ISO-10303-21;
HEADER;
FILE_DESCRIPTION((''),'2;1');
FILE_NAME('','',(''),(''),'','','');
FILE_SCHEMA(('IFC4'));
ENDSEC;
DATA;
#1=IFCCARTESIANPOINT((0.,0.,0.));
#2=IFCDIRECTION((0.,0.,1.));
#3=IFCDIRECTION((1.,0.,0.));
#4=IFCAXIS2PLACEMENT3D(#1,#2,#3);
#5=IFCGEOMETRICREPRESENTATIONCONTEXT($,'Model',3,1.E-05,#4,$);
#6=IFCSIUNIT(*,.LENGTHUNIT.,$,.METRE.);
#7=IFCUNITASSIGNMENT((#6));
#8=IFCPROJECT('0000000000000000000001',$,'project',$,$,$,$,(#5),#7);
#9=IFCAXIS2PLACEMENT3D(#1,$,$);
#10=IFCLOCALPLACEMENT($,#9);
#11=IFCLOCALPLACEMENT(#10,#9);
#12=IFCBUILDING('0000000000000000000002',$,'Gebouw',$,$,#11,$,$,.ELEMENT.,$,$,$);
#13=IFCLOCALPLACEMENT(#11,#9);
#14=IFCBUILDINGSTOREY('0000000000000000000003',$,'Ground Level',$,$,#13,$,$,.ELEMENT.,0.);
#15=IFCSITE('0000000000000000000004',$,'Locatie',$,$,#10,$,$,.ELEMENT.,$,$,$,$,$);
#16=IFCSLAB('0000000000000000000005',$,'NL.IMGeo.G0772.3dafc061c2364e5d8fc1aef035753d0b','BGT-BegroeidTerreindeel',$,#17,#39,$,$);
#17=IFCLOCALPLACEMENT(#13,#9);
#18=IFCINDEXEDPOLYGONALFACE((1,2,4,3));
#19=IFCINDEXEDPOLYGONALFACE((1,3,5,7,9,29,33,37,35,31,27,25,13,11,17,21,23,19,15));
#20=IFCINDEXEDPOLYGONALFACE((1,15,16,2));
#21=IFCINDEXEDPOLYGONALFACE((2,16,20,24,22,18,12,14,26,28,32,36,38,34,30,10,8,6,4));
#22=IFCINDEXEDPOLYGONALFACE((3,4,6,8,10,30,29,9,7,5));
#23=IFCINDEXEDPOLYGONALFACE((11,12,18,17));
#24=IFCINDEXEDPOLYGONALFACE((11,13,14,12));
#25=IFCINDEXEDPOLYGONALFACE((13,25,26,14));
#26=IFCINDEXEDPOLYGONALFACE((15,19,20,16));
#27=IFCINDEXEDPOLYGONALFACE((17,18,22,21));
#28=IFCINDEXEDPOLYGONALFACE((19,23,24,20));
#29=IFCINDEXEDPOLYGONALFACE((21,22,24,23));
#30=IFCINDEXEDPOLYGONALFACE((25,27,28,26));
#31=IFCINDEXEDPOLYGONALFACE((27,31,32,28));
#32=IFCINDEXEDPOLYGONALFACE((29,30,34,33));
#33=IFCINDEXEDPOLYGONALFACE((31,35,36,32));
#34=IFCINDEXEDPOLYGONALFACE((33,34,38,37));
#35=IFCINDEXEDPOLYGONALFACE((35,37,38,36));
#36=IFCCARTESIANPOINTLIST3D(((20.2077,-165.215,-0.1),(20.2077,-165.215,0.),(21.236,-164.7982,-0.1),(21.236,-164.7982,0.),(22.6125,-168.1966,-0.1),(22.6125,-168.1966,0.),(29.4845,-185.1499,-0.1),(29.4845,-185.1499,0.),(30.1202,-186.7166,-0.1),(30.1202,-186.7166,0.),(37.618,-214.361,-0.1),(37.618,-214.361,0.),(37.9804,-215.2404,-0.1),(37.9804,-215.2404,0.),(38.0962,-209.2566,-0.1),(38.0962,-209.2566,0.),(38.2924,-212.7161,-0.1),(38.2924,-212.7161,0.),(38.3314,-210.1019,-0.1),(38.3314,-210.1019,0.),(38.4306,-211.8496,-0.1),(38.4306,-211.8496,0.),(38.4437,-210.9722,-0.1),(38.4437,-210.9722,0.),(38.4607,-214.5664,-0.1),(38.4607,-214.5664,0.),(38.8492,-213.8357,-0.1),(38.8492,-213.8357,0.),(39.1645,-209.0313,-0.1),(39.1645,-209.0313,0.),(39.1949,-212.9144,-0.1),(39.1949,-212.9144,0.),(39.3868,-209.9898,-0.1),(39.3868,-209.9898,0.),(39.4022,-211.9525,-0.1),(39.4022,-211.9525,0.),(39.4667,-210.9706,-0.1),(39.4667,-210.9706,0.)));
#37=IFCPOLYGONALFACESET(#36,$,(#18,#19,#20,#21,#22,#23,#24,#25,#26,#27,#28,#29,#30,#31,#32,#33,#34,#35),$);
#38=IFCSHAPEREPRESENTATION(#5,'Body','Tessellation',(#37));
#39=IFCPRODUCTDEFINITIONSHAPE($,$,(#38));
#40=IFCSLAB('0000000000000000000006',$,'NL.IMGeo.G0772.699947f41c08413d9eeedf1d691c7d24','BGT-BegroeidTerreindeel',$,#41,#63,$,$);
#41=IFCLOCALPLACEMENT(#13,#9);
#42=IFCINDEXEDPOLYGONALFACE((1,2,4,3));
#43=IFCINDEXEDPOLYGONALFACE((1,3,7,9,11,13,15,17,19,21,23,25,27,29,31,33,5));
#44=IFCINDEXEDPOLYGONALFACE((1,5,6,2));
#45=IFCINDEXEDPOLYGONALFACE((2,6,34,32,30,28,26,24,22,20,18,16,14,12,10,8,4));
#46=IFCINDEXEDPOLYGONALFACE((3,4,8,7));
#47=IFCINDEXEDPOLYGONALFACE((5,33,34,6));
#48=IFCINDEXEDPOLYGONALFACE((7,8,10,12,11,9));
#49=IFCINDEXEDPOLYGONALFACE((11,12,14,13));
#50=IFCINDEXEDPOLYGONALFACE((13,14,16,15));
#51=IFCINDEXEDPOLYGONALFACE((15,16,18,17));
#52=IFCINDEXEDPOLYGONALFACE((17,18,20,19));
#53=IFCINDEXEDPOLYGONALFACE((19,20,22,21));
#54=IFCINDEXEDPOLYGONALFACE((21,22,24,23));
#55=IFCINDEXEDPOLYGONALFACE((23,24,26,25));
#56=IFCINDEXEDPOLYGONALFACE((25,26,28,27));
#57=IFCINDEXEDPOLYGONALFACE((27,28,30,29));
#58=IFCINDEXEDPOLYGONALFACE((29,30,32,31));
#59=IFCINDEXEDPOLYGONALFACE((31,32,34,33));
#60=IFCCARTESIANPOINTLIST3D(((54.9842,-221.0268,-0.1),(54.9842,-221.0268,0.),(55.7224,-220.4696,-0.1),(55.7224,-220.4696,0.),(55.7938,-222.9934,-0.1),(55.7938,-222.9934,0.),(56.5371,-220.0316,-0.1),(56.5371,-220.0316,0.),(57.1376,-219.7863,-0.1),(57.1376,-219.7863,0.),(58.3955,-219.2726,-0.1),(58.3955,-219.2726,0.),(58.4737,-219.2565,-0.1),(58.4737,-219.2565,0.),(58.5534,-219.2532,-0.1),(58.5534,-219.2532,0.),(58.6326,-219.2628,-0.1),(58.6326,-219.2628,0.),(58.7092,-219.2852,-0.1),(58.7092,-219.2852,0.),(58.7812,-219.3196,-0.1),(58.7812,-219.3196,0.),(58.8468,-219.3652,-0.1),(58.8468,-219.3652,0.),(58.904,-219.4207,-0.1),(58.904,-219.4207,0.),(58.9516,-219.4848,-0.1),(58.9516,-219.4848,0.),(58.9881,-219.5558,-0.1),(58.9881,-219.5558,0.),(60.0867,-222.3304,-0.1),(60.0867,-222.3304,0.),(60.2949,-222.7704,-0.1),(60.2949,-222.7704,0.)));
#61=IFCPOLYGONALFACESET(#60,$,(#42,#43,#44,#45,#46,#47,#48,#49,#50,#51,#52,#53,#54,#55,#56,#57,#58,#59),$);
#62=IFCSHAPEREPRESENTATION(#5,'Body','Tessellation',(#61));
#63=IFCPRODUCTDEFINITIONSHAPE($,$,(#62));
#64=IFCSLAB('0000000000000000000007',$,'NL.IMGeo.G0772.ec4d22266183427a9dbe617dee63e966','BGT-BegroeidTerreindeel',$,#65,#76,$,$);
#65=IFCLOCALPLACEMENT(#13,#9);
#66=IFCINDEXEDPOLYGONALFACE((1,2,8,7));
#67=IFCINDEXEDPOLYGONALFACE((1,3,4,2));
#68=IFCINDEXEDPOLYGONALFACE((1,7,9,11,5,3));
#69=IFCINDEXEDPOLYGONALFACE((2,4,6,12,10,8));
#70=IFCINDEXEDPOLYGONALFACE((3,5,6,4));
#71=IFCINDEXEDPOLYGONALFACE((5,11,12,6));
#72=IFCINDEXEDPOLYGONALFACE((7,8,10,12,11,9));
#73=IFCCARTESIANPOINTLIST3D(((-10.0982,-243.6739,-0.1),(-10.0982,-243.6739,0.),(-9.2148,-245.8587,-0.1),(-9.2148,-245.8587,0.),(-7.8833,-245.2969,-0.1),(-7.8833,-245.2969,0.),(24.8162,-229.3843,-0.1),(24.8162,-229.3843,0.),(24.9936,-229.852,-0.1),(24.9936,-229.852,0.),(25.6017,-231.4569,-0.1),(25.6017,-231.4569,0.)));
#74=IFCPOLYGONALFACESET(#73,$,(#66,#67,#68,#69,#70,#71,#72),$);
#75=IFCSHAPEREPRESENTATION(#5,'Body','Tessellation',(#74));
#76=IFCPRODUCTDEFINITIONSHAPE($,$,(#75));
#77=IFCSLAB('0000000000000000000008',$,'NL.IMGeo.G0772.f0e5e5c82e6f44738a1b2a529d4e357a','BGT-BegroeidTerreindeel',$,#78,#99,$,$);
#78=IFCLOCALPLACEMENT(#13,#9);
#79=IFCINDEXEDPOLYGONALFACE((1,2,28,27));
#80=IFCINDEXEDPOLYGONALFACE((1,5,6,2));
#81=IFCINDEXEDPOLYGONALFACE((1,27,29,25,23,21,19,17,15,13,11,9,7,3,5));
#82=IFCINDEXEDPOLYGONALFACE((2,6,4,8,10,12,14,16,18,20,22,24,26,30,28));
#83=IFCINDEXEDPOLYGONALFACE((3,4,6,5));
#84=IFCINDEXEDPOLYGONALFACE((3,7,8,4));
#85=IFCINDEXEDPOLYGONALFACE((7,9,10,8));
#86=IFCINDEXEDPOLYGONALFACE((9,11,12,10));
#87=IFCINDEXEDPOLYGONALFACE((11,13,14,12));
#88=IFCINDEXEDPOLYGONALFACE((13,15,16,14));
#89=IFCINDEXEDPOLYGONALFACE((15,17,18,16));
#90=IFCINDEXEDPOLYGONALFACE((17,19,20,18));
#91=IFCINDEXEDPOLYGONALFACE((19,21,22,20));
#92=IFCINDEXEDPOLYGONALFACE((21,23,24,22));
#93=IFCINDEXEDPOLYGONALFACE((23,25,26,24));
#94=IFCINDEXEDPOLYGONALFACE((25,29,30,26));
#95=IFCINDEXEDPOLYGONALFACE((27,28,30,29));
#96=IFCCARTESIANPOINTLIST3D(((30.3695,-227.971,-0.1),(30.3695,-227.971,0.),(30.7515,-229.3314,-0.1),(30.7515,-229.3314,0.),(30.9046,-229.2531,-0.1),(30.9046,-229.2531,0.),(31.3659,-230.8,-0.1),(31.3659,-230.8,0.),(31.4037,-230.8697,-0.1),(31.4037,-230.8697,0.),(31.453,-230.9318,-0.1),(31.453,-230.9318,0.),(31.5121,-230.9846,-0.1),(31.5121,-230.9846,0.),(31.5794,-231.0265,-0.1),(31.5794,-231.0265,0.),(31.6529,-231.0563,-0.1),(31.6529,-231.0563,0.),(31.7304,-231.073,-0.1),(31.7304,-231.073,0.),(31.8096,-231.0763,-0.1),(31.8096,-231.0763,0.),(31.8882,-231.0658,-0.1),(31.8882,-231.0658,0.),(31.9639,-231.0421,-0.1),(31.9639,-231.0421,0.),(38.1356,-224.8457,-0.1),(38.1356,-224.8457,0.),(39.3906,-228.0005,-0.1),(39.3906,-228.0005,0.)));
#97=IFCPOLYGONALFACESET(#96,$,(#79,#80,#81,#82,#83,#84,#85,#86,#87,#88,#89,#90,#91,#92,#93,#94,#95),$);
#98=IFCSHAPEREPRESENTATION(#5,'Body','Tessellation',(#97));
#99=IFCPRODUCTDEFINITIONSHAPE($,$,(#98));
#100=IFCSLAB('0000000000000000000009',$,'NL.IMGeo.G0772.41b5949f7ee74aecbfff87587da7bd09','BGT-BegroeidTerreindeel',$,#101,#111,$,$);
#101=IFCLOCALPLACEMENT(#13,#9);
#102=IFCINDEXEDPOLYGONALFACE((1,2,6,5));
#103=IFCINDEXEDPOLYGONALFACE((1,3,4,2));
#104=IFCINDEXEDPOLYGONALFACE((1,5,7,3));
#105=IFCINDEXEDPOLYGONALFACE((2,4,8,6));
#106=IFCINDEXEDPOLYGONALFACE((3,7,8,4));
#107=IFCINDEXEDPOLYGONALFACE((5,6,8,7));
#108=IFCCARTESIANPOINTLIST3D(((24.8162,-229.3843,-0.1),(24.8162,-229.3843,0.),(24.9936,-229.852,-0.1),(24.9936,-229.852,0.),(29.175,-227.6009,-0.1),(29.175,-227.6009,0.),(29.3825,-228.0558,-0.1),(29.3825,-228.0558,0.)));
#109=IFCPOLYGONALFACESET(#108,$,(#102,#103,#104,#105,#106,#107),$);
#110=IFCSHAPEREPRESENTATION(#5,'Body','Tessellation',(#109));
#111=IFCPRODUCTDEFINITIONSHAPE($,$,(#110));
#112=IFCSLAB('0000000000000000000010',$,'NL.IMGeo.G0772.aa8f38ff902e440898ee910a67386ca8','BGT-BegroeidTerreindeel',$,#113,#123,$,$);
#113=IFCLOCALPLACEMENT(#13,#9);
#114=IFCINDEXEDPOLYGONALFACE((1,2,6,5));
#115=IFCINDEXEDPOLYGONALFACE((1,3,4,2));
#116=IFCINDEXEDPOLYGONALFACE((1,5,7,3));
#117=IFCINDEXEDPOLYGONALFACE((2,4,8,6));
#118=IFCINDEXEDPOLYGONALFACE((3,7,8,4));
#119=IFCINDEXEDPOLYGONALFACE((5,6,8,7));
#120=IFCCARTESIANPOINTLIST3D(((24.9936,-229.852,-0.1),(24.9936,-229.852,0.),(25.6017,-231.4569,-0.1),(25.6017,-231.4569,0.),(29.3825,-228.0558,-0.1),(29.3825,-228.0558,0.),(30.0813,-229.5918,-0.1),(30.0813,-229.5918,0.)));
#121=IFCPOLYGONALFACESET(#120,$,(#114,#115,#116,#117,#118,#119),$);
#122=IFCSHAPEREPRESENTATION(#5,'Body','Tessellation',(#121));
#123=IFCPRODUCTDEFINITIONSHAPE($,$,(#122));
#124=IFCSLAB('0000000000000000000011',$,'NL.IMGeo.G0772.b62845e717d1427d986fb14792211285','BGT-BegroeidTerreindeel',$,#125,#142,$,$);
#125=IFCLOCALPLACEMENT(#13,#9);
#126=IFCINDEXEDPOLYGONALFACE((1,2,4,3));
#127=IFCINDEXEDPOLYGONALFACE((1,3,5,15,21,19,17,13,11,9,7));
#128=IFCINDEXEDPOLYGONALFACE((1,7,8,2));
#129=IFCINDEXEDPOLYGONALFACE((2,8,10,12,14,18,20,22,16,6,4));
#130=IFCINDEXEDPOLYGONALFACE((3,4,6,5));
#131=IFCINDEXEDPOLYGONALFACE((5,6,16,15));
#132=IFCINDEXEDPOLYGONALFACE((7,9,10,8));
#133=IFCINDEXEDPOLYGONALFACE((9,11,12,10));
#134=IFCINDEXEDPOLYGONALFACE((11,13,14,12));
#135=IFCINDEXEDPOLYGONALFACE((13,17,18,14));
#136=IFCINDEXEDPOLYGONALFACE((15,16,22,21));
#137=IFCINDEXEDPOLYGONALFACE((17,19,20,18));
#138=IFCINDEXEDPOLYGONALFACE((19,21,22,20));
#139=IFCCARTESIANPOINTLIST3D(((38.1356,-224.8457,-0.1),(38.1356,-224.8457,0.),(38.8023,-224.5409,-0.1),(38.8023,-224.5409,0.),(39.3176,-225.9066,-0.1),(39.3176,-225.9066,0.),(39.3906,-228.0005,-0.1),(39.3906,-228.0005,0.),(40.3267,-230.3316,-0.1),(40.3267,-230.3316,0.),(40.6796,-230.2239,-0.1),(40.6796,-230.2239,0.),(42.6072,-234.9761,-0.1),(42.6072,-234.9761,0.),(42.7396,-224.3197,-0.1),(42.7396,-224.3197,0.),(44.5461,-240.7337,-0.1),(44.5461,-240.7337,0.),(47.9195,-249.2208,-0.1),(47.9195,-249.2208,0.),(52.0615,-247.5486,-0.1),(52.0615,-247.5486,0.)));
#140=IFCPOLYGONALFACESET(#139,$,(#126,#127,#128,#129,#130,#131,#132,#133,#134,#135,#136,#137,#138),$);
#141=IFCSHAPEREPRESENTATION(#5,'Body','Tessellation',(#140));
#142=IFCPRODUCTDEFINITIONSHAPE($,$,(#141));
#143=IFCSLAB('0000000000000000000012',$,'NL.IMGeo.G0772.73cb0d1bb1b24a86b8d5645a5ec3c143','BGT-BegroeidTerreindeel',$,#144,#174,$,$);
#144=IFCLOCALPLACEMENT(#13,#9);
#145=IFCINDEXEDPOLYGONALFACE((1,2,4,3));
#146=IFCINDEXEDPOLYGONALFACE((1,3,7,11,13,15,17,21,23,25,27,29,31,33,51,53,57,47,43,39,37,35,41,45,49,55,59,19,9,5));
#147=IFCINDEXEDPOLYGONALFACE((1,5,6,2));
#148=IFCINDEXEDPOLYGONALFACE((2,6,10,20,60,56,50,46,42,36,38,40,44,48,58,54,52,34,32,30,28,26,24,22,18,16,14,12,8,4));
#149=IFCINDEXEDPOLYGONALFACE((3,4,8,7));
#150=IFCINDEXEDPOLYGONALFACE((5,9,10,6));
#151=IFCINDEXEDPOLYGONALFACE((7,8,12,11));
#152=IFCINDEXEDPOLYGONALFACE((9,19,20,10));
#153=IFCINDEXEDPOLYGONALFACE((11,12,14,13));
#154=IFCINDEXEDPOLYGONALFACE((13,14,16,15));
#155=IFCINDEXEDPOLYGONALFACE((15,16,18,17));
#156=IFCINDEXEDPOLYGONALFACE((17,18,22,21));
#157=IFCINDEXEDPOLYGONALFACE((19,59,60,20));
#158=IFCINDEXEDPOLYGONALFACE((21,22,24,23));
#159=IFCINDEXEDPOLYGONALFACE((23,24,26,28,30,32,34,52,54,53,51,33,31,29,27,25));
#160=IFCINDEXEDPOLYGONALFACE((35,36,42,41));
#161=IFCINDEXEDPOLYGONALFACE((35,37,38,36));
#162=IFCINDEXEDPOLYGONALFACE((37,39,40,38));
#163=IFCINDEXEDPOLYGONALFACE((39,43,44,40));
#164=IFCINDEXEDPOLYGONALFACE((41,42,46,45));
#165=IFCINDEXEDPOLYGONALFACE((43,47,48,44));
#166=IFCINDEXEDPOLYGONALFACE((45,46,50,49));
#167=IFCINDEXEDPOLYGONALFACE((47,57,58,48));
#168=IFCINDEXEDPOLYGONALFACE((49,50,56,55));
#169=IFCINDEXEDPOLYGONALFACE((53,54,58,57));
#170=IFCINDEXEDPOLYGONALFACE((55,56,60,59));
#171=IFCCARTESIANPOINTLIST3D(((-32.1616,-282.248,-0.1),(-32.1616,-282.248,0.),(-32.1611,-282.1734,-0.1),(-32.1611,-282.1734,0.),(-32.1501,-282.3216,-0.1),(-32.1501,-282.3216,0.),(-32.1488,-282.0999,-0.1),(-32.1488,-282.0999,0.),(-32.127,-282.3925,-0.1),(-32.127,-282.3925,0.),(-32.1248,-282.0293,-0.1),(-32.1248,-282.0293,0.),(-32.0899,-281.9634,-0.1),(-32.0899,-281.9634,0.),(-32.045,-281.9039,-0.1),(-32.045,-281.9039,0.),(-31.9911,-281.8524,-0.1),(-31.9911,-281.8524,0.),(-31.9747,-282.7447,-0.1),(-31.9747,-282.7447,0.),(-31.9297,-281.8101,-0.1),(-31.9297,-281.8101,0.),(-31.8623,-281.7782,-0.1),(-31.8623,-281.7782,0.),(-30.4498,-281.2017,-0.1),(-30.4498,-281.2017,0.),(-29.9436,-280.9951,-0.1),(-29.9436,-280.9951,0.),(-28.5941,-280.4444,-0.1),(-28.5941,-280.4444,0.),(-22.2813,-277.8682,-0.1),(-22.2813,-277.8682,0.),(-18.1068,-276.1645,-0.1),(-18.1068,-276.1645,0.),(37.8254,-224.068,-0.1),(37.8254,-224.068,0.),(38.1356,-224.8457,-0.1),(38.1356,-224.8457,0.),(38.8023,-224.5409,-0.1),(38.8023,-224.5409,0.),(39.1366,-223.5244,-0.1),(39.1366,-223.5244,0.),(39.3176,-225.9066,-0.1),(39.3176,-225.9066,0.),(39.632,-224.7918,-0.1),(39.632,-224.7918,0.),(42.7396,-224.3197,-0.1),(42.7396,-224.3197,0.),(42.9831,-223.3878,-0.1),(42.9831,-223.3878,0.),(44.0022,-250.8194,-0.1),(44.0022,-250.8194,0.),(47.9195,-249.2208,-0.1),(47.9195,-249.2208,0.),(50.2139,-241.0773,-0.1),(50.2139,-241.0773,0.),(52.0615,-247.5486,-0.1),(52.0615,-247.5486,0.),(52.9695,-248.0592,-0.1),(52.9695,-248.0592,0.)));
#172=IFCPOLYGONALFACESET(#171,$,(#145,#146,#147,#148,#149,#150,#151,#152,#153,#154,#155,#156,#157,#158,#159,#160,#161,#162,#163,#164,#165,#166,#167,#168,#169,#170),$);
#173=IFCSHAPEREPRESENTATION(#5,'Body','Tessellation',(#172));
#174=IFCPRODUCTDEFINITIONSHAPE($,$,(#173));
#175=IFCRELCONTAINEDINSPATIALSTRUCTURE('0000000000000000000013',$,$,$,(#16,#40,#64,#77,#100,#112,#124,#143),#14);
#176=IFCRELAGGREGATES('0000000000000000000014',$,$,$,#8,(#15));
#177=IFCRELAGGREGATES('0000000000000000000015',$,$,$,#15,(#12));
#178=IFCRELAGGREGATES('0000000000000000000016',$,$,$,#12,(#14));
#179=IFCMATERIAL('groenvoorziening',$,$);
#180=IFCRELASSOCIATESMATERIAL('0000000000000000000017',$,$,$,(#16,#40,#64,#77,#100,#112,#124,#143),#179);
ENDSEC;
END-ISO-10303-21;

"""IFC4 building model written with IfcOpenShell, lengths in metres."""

from ifc_helpers import new_model, si_unit, frame, origin, origin_with_axes, place, context, project, spatial, polyline, outline, extrude, material, element, save


model = new_model("IFC4")

# Units and contexts
model_context = context("Model", 3, precision=1e-05, world=origin_with_axes())
ifc_project = project(units=[si_unit("LENGTHUNIT", "METRE")], contexts=[model_context])

# Site, building, storey
site_placement = place(None, origin())
site = spatial("IfcSite", under=ifc_project, at=site_placement, Name="Locatie", CompositionType="ELEMENT")
building_placement = place(site_placement, origin())
building = spatial("IfcBuilding", under=site, at=building_placement, Name="Gebouw", CompositionType="ELEMENT")
storey_placement = place(building_placement, origin())
storey = spatial("IfcBuildingStorey", under=building, at=storey_placement, Name="Ground Level", CompositionType="ELEMENT", Elevation=0.0)

# Slabs
ifc_material_1 = material(Name="groenvoorziening")
slab_1_placement = place(storey_placement, origin())
element("IfcSlab", 1, at=slab_1_placement, inside=storey, material=ifc_material_1, Name="NL.IMGeo.G0772.3dafc061c2364e5d8fc1aef035753d0b", Description="BGT-BegroeidTerreindeel", context=model_context, shape_type="SweptSolid", body=[
    extrude(outline(polyline([(29.4845, -185.1499), (30.1202, -186.7166), (39.1645, -209.0313), (39.3868, -209.9898), (39.4667, -210.9706), (39.4022, -211.9525), (39.1949, -212.9144), (38.8492, -213.8357), (38.4607, -214.5664), (37.9804, -215.2404), (37.618, -214.361), (38.2924, -212.7161), (38.4306, -211.8496), (38.4437, -210.9722), (38.3314, -210.1019), (38.0962, -209.2566), (20.2077, -165.215), (21.236, -164.7982), (22.6125, -168.1966), (29.4845, -185.1499)])), frame((0.0, 0.0, -0.1), z_axis=(0.0, 0.0, 1.0), x_axis=(1.0, 0.0, 0.0)), (0.0, 0.0, 1.0), 0.1),
])
slab_2_placement = place(storey_placement, origin())
element("IfcSlab", 2, at=slab_2_placement, inside=storey, material=ifc_material_1, Name="NL.IMGeo.G0772.699947f41c08413d9eeedf1d691c7d24", Description="BGT-BegroeidTerreindeel", context=model_context, shape_type="SweptSolid", body=[
    extrude(outline(polyline([(60.0867, -222.3304), (60.2949, -222.7704), (55.7938, -222.9934), (54.9842, -221.0268), (55.7224, -220.4696), (56.5371, -220.0316), (57.1376, -219.7863), (58.3955, -219.2726), (58.4737, -219.2565), (58.5534, -219.2532), (58.6326, -219.2628), (58.7092, -219.2852), (58.7812, -219.3196), (58.8468, -219.3652), (58.904, -219.4207), (58.9516, -219.4848), (58.9881, -219.5558), (60.0867, -222.3304)])), frame((0.0, 0.0, -0.1), z_axis=(0.0, 0.0, 1.0), x_axis=(1.0, 0.0, 0.0)), (0.0, 0.0, 1.0), 0.1),
])
slab_3_placement = place(storey_placement, origin())
element("IfcSlab", 3, at=slab_3_placement, inside=storey, material=ifc_material_1, Name="NL.IMGeo.G0772.ec4d22266183427a9dbe617dee63e966", Description="BGT-BegroeidTerreindeel", context=model_context, shape_type="SweptSolid", body=[
    extrude(outline(polyline([(24.8162, -229.3843), (24.9936, -229.852), (25.6017, -231.4569), (-7.8833, -245.2969), (-9.2148, -245.8587), (-10.0982, -243.6739), (24.8162, -229.3843)])), frame((0.0, 0.0, -0.1), z_axis=(0.0, 0.0, 1.0), x_axis=(1.0, 0.0, 0.0)), (0.0, 0.0, 1.0), 0.1),
])
slab_4_placement = place(storey_placement, origin())
element("IfcSlab", 4, at=slab_4_placement, inside=storey, material=ifc_material_1, Name="NL.IMGeo.G0772.f0e5e5c82e6f44738a1b2a529d4e357a", Description="BGT-BegroeidTerreindeel", context=model_context, shape_type="SweptSolid", body=[
    extrude(outline(polyline([(38.1356, -224.8457), (39.3906, -228.0005), (31.9639, -231.0421), (31.8882, -231.0658), (31.8096, -231.0763), (31.7304, -231.073), (31.6529, -231.0563), (31.5794, -231.0265), (31.5121, -230.9846), (31.453, -230.9318), (31.4037, -230.8697), (31.3659, -230.8), (30.7515, -229.3314), (30.9046, -229.2531), (30.3695, -227.971), (38.1356, -224.8457)])), frame((0.0, 0.0, -0.1), z_axis=(0.0, 0.0, 1.0), x_axis=(1.0, 0.0, 0.0)), (0.0, 0.0, 1.0), 0.1),
])
slab_5_placement = place(storey_placement, origin())
element("IfcSlab", 5, at=slab_5_placement, inside=storey, material=ifc_material_1, Name="NL.IMGeo.G0772.41b5949f7ee74aecbfff87587da7bd09", Description="BGT-BegroeidTerreindeel", context=model_context, shape_type="SweptSolid", body=[
    extrude(outline(polyline([(29.3825, -228.0558), (24.9936, -229.852), (24.8162, -229.3843), (29.175, -227.6009), (29.3825, -228.0558)])), frame((0.0, 0.0, -0.1), z_axis=(0.0, 0.0, 1.0), x_axis=(1.0, 0.0, 0.0)), (0.0, 0.0, 1.0), 0.1),
])
slab_6_placement = place(storey_placement, origin())
element("IfcSlab", 6, at=slab_6_placement, inside=storey, material=ifc_material_1, Name="NL.IMGeo.G0772.aa8f38ff902e440898ee910a67386ca8", Description="BGT-BegroeidTerreindeel", context=model_context, shape_type="SweptSolid", body=[
    extrude(outline(polyline([(29.3825, -228.0558), (30.0813, -229.5918), (25.6017, -231.4569), (24.9936, -229.852), (29.3825, -228.0558)])), frame((0.0, 0.0, -0.1), z_axis=(0.0, 0.0, 1.0), x_axis=(1.0, 0.0, 0.0)), (0.0, 0.0, 1.0), 0.1),
])
slab_7_placement = place(storey_placement, origin())
element("IfcSlab", 7, at=slab_7_placement, inside=storey, material=ifc_material_1, Name="NL.IMGeo.G0772.b62845e717d1427d986fb14792211285", Description="BGT-BegroeidTerreindeel", context=model_context, shape_type="SweptSolid", body=[
    extrude(outline(polyline([(38.8023, -224.5409), (39.3176, -225.9066), (42.7396, -224.3197), (52.0615, -247.5486), (47.9195, -249.2208), (44.5461, -240.7337), (42.6072, -234.9761), (40.6796, -230.2239), (40.3267, -230.3316), (39.3906, -228.0005), (38.1356, -224.8457), (38.8023, -224.5409)])), frame((0.0, 0.0, -0.1), z_axis=(0.0, 0.0, 1.0), x_axis=(1.0, 0.0, 0.0)), (0.0, 0.0, 1.0), 0.1),
])
slab_8_placement = place(storey_placement, origin())
element("IfcSlab", 8, at=slab_8_placement, inside=storey, material=ifc_material_1, Name="NL.IMGeo.G0772.73cb0d1bb1b24a86b8d5645a5ec3c143", Description="BGT-BegroeidTerreindeel", context=model_context, shape_type="SweptSolid", body=[
    extrude(outline(polyline([(-28.5941, -280.4444), (-22.2813, -277.8682), (-18.1068, -276.1645), (44.0022, -250.8194), (47.9195, -249.2208), (52.0615, -247.5486), (42.7396, -224.3197), (39.3176, -225.9066), (38.8023, -224.5409), (38.1356, -224.8457), (37.8254, -224.068), (39.1366, -223.5244), (39.632, -224.7918), (42.9831, -223.3878), (50.2139, -241.0773), (52.9695, -248.0592), (-31.9747, -282.7447), (-32.127, -282.3925), (-32.1501, -282.3216), (-32.1616, -282.248), (-32.1611, -282.1734), (-32.1488, -282.0999), (-32.1248, -282.0293), (-32.0899, -281.9634), (-32.045, -281.9039), (-31.9911, -281.8524), (-31.9297, -281.8101), (-31.8623, -281.7782), (-30.4498, -281.2017), (-29.9436, -280.9951), (-28.5941, -280.4444)])), frame((0.0, 0.0, -0.1), z_axis=(0.0, 0.0, 1.0), x_axis=(1.0, 0.0, 0.0)), (0.0, 0.0, 1.0), 0.1),
])

save(model, "model.ifc")
